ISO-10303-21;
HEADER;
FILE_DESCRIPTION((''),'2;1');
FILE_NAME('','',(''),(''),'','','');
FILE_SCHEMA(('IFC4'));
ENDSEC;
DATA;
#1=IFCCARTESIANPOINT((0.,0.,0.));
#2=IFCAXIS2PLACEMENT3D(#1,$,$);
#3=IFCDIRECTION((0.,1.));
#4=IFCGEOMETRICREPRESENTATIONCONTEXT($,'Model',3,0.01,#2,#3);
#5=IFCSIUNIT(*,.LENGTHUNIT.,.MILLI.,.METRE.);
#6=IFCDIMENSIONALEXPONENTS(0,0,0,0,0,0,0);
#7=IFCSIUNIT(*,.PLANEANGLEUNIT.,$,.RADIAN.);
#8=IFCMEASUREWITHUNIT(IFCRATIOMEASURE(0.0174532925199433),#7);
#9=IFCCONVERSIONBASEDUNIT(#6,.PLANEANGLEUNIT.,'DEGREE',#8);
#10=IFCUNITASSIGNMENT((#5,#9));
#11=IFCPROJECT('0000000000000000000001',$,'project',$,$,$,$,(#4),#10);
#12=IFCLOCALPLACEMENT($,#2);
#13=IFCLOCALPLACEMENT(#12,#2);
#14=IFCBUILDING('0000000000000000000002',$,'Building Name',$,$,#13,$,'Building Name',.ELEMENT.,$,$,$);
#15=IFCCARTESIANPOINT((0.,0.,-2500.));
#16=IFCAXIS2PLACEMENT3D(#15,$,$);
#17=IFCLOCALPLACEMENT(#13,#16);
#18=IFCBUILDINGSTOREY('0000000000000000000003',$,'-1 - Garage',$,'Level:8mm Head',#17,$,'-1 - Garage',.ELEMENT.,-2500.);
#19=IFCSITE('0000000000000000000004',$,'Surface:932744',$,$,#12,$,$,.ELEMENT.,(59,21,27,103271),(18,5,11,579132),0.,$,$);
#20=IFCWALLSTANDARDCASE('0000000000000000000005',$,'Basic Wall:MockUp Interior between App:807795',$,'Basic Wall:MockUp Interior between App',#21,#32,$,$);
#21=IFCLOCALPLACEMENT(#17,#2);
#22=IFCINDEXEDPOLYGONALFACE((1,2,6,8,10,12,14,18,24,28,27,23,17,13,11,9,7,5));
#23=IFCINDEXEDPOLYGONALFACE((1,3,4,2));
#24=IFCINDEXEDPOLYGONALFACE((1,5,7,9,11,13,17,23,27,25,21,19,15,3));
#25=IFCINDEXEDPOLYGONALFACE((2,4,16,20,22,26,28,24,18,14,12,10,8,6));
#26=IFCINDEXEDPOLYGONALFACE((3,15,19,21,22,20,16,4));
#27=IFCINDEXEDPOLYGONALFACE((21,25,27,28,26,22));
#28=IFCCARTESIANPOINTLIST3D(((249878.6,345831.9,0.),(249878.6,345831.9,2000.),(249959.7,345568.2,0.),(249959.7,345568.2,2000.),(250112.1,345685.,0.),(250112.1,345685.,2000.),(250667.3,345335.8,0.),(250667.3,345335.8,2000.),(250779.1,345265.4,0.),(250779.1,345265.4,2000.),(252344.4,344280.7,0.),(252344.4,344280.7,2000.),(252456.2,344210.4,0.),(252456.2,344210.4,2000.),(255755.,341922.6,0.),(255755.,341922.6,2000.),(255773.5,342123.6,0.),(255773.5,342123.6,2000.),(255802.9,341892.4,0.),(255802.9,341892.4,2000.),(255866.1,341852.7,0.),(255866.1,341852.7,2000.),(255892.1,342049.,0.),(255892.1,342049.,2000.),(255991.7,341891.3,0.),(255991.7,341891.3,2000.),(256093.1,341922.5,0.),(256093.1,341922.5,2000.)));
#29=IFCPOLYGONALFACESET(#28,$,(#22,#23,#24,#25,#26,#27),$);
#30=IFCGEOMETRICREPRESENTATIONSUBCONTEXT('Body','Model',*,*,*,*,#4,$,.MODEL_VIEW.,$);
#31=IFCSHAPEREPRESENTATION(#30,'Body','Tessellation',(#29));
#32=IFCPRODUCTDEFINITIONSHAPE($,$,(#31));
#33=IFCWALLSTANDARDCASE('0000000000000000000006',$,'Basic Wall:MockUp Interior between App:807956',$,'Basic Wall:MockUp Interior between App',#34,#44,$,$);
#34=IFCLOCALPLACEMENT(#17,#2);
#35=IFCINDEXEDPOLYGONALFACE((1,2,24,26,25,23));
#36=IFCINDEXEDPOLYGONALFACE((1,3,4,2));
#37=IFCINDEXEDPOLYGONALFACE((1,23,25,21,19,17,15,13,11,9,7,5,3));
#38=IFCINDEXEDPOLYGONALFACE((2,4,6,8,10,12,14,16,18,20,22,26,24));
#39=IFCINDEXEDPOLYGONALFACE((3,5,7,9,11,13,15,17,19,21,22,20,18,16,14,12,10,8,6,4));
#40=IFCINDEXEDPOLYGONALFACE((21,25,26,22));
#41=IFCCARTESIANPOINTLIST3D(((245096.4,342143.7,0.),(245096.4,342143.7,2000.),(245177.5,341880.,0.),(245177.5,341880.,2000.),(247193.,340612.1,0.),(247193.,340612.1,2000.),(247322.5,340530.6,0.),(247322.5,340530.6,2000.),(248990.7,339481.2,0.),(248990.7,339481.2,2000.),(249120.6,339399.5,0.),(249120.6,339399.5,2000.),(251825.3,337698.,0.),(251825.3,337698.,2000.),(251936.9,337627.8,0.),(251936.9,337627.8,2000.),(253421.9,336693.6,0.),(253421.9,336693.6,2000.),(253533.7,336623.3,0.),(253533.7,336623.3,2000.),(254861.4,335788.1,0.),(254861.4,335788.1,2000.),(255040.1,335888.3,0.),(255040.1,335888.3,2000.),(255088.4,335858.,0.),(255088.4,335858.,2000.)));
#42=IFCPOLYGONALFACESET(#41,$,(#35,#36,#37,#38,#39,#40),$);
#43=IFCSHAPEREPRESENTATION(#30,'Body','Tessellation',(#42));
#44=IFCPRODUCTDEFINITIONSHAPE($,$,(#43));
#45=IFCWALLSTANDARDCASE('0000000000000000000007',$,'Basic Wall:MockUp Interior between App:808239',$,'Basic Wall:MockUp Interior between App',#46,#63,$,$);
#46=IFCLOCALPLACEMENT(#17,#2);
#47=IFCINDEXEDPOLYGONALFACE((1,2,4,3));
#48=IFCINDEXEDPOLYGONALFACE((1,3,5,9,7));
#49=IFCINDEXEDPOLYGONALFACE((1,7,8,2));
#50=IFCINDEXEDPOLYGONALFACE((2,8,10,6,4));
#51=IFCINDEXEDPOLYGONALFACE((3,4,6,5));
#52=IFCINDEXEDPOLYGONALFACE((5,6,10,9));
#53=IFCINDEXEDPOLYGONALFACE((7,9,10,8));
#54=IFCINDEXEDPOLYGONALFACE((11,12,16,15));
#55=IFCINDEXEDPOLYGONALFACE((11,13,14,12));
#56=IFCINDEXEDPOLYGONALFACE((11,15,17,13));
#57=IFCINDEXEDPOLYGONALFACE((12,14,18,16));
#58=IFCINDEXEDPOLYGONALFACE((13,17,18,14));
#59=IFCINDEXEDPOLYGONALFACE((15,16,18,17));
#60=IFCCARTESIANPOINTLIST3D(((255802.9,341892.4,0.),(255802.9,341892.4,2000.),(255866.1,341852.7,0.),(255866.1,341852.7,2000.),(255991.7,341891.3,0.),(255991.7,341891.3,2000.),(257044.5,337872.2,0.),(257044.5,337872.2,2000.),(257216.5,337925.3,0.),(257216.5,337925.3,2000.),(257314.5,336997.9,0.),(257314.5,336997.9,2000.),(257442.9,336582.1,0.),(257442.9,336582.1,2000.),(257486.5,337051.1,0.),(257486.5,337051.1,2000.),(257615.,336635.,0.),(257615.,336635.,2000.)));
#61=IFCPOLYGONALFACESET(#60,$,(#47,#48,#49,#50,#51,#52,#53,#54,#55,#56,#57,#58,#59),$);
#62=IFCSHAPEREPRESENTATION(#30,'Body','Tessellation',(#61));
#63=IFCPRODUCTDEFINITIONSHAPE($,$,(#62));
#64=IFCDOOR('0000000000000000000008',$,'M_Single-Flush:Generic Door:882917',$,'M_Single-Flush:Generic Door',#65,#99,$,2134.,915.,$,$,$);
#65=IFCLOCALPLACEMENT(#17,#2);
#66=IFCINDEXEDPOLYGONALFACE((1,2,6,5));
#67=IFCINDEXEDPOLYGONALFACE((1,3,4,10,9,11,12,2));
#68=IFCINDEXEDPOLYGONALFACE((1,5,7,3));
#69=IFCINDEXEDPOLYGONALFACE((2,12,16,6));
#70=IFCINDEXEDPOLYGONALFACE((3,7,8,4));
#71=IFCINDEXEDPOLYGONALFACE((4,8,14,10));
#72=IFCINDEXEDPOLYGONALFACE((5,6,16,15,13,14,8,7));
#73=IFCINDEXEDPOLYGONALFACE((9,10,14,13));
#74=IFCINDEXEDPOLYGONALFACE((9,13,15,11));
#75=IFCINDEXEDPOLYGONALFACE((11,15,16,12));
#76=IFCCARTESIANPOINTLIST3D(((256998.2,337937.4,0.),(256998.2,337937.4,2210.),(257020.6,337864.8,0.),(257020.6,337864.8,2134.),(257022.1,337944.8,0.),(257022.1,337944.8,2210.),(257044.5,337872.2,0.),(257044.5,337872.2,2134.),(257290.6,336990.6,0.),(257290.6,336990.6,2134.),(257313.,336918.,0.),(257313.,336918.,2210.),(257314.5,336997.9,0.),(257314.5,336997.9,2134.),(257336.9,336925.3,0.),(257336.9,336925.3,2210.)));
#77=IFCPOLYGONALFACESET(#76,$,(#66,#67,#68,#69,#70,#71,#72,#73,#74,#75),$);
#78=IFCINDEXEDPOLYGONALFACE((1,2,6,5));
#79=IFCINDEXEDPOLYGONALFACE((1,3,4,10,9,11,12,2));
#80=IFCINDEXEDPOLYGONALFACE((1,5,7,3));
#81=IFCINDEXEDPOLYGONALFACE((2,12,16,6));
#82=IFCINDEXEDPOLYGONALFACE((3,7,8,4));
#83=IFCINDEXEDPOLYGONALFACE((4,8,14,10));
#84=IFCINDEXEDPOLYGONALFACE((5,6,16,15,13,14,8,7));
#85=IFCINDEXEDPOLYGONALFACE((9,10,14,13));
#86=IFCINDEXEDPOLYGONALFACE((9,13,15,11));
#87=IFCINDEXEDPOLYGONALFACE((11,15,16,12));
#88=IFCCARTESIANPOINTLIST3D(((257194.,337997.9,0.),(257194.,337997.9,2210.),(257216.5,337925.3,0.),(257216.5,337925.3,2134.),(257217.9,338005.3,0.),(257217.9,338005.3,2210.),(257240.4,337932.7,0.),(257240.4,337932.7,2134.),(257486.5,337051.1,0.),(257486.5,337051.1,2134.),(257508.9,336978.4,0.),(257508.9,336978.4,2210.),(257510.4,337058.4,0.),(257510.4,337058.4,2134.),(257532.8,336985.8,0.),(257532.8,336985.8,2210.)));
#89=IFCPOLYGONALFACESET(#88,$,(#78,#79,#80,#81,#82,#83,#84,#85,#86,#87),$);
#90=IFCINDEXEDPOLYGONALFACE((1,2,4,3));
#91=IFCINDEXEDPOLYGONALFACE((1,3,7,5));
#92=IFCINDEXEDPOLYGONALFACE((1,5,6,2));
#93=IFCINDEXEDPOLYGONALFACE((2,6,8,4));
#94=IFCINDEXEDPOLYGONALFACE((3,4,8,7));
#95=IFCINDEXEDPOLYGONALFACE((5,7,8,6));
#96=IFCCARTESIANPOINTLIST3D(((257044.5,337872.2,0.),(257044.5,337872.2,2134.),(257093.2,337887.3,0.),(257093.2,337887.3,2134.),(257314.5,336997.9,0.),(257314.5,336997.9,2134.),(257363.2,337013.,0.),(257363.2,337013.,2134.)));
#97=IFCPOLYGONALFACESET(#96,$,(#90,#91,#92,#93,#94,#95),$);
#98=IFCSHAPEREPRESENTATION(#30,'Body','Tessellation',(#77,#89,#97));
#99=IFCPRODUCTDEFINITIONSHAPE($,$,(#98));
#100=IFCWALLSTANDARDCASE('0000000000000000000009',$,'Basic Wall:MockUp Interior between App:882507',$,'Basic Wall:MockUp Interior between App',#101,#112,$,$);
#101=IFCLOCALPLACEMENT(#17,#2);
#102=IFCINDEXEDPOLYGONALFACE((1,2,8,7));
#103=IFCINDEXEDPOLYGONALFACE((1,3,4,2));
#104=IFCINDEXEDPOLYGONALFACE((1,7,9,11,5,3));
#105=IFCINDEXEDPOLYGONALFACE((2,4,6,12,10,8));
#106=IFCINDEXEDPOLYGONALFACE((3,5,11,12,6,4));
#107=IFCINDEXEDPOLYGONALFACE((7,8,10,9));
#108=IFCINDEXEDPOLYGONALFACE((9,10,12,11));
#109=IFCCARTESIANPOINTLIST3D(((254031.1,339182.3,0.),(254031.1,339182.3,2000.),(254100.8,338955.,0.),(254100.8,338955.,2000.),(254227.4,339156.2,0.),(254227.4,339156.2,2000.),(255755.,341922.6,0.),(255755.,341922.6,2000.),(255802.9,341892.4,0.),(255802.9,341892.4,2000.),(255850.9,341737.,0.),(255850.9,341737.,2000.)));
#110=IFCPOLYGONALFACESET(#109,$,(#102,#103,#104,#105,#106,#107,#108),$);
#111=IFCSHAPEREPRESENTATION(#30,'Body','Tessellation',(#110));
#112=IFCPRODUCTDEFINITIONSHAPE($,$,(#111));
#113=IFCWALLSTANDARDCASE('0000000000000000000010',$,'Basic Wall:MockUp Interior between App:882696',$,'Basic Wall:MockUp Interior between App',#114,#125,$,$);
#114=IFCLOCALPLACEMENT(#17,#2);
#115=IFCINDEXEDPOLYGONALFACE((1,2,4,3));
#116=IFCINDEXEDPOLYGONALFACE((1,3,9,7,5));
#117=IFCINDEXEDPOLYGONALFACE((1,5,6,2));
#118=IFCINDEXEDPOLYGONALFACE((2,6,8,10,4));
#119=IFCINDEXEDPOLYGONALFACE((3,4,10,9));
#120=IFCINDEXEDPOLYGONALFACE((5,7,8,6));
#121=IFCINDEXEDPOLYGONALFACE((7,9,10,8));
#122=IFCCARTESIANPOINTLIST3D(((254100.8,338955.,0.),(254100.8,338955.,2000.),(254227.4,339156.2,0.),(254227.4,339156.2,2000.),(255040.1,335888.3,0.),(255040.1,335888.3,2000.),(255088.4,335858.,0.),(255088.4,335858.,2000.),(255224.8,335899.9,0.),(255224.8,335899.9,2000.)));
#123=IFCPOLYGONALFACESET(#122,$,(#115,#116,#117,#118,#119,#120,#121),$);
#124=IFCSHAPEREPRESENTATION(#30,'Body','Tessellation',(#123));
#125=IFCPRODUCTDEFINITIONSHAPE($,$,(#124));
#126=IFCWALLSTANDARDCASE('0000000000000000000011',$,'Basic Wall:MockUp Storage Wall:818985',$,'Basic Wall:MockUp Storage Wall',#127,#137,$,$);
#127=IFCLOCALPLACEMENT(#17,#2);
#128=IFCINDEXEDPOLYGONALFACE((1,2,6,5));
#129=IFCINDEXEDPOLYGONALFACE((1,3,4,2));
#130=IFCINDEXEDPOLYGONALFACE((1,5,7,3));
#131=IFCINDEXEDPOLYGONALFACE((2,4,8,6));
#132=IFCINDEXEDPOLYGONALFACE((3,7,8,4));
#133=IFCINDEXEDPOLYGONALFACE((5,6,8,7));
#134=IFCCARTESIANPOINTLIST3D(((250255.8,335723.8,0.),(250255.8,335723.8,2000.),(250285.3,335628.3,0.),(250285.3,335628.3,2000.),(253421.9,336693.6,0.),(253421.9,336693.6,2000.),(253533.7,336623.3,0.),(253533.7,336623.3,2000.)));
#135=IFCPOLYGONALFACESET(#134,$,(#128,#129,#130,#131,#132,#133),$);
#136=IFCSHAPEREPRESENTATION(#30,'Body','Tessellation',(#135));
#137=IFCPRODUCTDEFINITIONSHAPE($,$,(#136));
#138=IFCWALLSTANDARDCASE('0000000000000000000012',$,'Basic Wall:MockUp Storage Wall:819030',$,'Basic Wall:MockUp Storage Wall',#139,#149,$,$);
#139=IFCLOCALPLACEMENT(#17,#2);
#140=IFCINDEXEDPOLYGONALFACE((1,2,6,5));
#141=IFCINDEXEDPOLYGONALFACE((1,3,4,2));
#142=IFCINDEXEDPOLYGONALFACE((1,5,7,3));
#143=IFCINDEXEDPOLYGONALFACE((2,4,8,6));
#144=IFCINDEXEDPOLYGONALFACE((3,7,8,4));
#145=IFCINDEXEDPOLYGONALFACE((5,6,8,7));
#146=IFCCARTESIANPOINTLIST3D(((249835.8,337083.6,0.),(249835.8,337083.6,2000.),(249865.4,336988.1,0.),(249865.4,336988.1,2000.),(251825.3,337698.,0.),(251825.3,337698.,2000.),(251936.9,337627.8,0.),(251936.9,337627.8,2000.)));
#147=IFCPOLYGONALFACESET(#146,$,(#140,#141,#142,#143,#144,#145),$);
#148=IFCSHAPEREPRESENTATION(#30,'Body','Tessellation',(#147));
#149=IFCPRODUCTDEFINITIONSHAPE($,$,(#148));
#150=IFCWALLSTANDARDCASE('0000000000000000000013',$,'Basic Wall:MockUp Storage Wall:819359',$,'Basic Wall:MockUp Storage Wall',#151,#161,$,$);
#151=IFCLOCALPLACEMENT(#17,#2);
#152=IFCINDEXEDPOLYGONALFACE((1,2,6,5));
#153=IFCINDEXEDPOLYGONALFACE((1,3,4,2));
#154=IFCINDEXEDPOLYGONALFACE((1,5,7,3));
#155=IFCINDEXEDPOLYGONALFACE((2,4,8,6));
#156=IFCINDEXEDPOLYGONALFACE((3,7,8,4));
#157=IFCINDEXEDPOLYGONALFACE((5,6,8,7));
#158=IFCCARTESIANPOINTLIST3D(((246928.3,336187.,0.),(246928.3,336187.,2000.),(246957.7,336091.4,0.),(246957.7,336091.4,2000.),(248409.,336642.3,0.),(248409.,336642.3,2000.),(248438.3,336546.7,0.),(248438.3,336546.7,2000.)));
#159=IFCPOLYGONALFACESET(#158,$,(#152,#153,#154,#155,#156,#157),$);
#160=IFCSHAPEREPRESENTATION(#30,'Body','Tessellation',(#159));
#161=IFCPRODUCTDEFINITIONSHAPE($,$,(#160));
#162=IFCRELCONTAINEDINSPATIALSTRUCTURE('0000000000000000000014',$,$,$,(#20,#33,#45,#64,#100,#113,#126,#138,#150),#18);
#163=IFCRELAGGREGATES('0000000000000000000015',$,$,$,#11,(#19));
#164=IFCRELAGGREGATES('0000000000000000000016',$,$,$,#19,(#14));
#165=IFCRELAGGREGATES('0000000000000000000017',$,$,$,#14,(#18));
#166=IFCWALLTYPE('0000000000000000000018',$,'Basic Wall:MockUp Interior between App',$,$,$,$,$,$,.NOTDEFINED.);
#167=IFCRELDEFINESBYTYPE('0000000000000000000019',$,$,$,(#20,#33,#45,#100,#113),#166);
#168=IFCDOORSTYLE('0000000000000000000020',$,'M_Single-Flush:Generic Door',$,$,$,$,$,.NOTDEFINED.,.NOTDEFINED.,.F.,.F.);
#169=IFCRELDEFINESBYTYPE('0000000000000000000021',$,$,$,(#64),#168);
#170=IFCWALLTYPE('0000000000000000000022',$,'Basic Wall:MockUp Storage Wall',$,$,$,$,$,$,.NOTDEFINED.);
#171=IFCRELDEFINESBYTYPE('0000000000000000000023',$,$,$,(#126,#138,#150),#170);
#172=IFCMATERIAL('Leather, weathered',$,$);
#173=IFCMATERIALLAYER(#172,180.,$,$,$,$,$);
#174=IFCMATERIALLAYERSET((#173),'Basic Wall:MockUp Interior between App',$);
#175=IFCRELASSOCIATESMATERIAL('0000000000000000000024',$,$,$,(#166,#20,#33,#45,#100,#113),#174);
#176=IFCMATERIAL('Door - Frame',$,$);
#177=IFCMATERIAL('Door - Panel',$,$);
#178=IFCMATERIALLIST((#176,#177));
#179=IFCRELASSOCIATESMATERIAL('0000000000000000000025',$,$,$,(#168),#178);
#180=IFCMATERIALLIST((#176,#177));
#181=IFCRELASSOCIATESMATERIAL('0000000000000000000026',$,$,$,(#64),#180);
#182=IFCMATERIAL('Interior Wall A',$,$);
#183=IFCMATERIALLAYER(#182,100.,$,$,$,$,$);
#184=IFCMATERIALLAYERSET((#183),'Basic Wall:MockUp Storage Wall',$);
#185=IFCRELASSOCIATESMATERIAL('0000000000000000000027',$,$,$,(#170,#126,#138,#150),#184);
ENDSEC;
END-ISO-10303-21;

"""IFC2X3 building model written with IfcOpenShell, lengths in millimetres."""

from ifc_helpers import new_model, entity, si_unit, converted_unit, direction, frame, frame_2d, origin, place, context, subcontext, project, spatial, polyline, rectangle, outline, extrude, source, transform, mapped, material, material_list, layer, layer_set, layer_usage, type_object, type_shapes, element, fill, save


model = new_model("IFC2X3")

# Units and contexts
model_context = context("Model", 3, precision=0.01, world=origin(), true_north=direction((0.0, 1.0)))
body_context = subcontext(model_context, "Body", "Model", "MODEL_VIEW")
ifc_project = project(units=[si_unit("LENGTHUNIT", "METRE", prefix="MILLI"), converted_unit("PLANEANGLEUNIT", "DEGREE", entity("IfcRatioMeasure", 0.0174532925199433), si_unit("PLANEANGLEUNIT", "RADIAN"), dimensions=[0, 0, 0, 0, 0, 0, 0])], contexts=[model_context])

# Site, building, storey
site_placement = place(None, origin())
site = spatial("IfcSite", under=ifc_project, at=site_placement, Name="Surface:932744", CompositionType="ELEMENT", RefLatitude=(59, 21, 27, 103271), RefLongitude=(18, 5, 11, 579132), RefElevation=0.0)
building_placement = place(site_placement, origin())
building = spatial("IfcBuilding", under=site, at=building_placement, Name="Building Name", LongName="Building Name", CompositionType="ELEMENT")
storey_placement = place(building_placement, frame((0.0, 0.0, -2500.0)))
storey = spatial("IfcBuildingStorey", under=building, at=storey_placement, Name="-1 - Garage", ObjectType="Level:8mm Head", LongName="-1 - Garage", CompositionType="ELEMENT", Elevation=-2500.0)

# Shared definitions
ifc_material_1 = material(Name="Leather, weathered")
ifc_layer_1 = layer(ifc_material_1, 180.0)
ifc_layer_set_1 = layer_set([ifc_layer_1], Name="Basic Wall:MockUp Interior between App")
wall_type_1 = type_object("IfcWallType", Name="Basic Wall:MockUp Interior between App", PredefinedType="NOTDEFINED", material=ifc_layer_set_1)
ifc_material_2 = material(Name="Door - Frame")
ifc_material_3 = material(Name="Door - Panel")

# Walls
ifc_layer_usage_1 = layer_usage(ifc_layer_set_1, "AXIS2", "NEGATIVE", 90.0)
wall_1_placement = place(storey_placement, frame((249830.7, 345755.7, 0.0), z_axis=(0.0, 0.0, 1.0), x_axis=(0.846444, -0.532477, 0.0)))
element("IfcWallStandardCase", 1, at=wall_1_placement, inside=storey, type_object=wall_type_1, material=ifc_layer_usage_1, Name="Basic Wall:MockUp Interior between App:807795", ObjectType="Basic Wall:MockUp Interior between App", context=body_context, shape_type="SweptSolid", body=[
    extrude(outline(polyline([(7186.9, -90.0), (7272.7, 9.6), (7341.9, 90.0), (7104.4, 90.0), (6964.3, 90.0), (3045.3, 90.0), (2913.2, 90.0), (1063.9, 90.0), (931.8, 90.0), (275.9, 90.0), (0.0, 90.0), (209.1, -90.0), (7055.7, -90.0), (7112.3, -90.0), (7186.9, -90.0)])), origin(), (0.0, 0.0, 1.0), 2000.0),
])
ifc_layer_usage_2 = layer_usage(ifc_layer_set_1, "AXIS2", "NEGATIVE", 90.0)
wall_2_placement = place(storey_placement, frame((245048.4, 342067.5, 0.0), z_axis=(0.0, 0.0, 1.0), x_axis=(0.846444, -0.532477, 0.0)))
element("IfcWallStandardCase", 2, at=wall_2_placement, inside=storey, type_object=wall_type_1, material=ifc_layer_usage_2, Name="Basic Wall:MockUp Interior between App:807956", ObjectType="Basic Wall:MockUp Interior between App", context=body_context, shape_type="SweptSolid", body=[
    extrude(outline(polyline([(11649.7, -90.0), (11804.7, 90.0), (11747.7, 90.0), (0.0, 90.0), (209.0, -90.0), (2590.2, -90.0), (2743.2, -90.0), (4714.1, -90.0), (4867.5, -90.0), (8062.9, -90.0), (8194.7, -90.0), (9949.1, -90.0), (10081.2, -90.0), (11649.7, -90.0)])), origin(), (0.0, 0.0, 1.0), 2000.0),
])

# Wall, opening, door
ifc_layer_usage_3 = layer_usage(ifc_layer_set_1, "AXIS2", "NEGATIVE", 90.0)
wall_3_placement = place(storey_placement, frame((255888.9, 341919.0, 0.0), z_axis=(0.0, 0.0, 1.0), x_axis=(0.29508, -0.955473, 0.0)))
wall_3 = element("IfcWallStandardCase", 3, at=wall_3_placement, inside=storey, type_object=wall_type_1, material=ifc_layer_usage_3, Name="Basic Wall:MockUp Interior between App:808239", ObjectType="Basic Wall:MockUp Interior between App", context=body_context, shape_type="SweptSolid", body=[
    extrude(outline(polyline([(56.8, 90.0), (56.6, -41.4), (0.0, -90.0), (5557.8, -90.0), (5558.0, 90.0), (56.8, 90.0)])), origin(), (0.0, 0.0, 1.0), 2000.0),
])
opening_1_placement = place(wall_3_placement, frame((5122.6, 90.0, 0.0)))
opening_1 = element("IfcOpeningElement", 4, at=opening_1_placement, cuts=wall_3, ObjectType="Opening", context=body_context, shape_type="SweptSolid", body=[
    extrude(rectangle(XDim=915.0, YDim=2134.0, at=frame_2d((1067.0, 457.5), x_axis=(0.0, -1.0))), frame((0.0, 0.0, 0.0), z_axis=(0.0, -1.0, 0.0), x_axis=(0.0, 0.0, 1.0)), (0.0, 0.0, 1.0), 180.0),
])
ifc_material_list_1 = material_list([ifc_material_2, ifc_material_3])
ifc_material_list_2 = material_list([ifc_material_2, ifc_material_3])
door_style_1 = type_object("IfcDoorStyle", Name="M_Single-Flush:Generic Door", ConstructionType="NOTDEFINED", OperationType="NOTDEFINED", ParameterTakesPrecedence=False, Sizeable=False, material=ifc_material_list_2)
shared_shape_1 = source(origin(), body_context, "Body", "SweptSolid", [
    extrude(outline(polyline([(-533.5, -1124.0), (533.5, -1124.0), (533.5, 1086.0), (457.5, 1086.0), (457.5, -1048.0), (-457.5, -1048.0), (-457.5, 1086.0), (-533.5, 1086.0), (-533.5, -1124.0)])), frame((457.5, 205.0, 1086.0), z_axis=(0.0, -1.0, 0.0), x_axis=(-1.0, 0.0, 0.0)), (0.0, 0.0, 1.0), 25.0),
    extrude(outline(polyline([(-1124.0, -533.5), (1086.0, -533.5), (1086.0, -457.5), (-1048.0, -457.5), (-1048.0, 457.5), (1086.0, 457.5), (1086.0, 533.5), (-1124.0, 533.5), (-1124.0, -533.5)])), frame((457.5, 0.0, 1086.0), z_axis=(0.0, -1.0, 0.0), x_axis=(0.0, 0.0, -1.0)), (0.0, 0.0, 1.0), 25.0),
    extrude(rectangle(XDim=915.0, YDim=51.0, at=frame_2d((0.0, 0.0), x_axis=(1.0, 0.0))), frame((457.5, 154.5, 0.0)), (0.0, 0.0, 1.0), 2134.0),
])
type_shapes(door_style_1, [shared_shape_1])
door_1_placement = place(opening_1_placement, frame((0.0, 0.0, 0.0), z_axis=(0.0, 0.0, 1.0), x_axis=(-1.0, 0.0, 0.0)))
door_1 = element("IfcDoor", 5, at=door_1_placement, inside=storey, type_object=door_style_1, material=ifc_material_list_1, Name="M_Single-Flush:Generic Door:882917", ObjectType="M_Single-Flush:Generic Door", OverallHeight=2134.0, OverallWidth=915.0, context=body_context, shape_type="MappedRepresentation", body=[
    mapped(shared_shape_1, transform((0.0, 0.0, 0.0), scale=1.0)),
])
fill(opening_1, door_1)

# Walls
ifc_layer_usage_4 = layer_usage(ifc_layer_set_1, "AXIS2", "NEGATIVE", 90.0)
wall_4_placement = place(storey_placement, frame((255831.1, 341874.6, 0.0), z_axis=(0.0, 0.0, 1.0), x_axis=(-0.532477, -0.846444, 0.0)))
element("IfcWallStandardCase", 6, at=wall_4_placement, inside=storey, type_object=wall_type_1, material=ifc_layer_usage_4, Name="Basic Wall:MockUp Interior between App:882507", ObjectType="Basic Wall:MockUp Interior between App", context=body_context, shape_type="SweptSolid", body=[
    extrude(outline(polyline([(3237.4, -90.0), (3392.7, 90.0), (3155.0, 90.0), (106.0, 90.0), (0.0, -33.3), (0.0, -90.0), (3237.4, -90.0)])), origin(), (0.0, 0.0, 1.0), 2000.0),
])
ifc_layer_usage_5 = layer_usage(ifc_layer_set_1, "AXIS2", "NEGATIVE", 90.0)
wall_5_placement = place(storey_placement, frame((254141.3, 339129.9, 0.0), z_axis=(0.0, 0.0, 1.0), x_axis=(0.29288, -0.956149, 0.0)))
element("IfcWallStandardCase", 7, at=wall_5_placement, inside=storey, type_object=wall_type_1, material=ifc_layer_usage_5, Name="Basic Wall:MockUp Interior between App:882696", ObjectType="Basic Wall:MockUp Interior between App", context=body_context, shape_type="SweptSolid", body=[
    extrude(outline(polyline([(3362.6, -90.0), (3405.8, -52.7), (3405.6, 90.0), (0.0, 90.0), (155.4, -90.0), (3362.6, -90.0)])), origin(), (0.0, 0.0, 1.0), 2000.0),
])

# Shared definitions
ifc_material_4 = material(Name="Interior Wall A")
ifc_layer_2 = layer(ifc_material_4, 100.0)
ifc_layer_set_2 = layer_set([ifc_layer_2], Name="Basic Wall:MockUp Storage Wall")
wall_type_2 = type_object("IfcWallType", Name="Basic Wall:MockUp Storage Wall", PredefinedType="NOTDEFINED", material=ifc_layer_set_2)

# Walls
ifc_layer_usage_6 = layer_usage(ifc_layer_set_2, "AXIS2", "NEGATIVE", 50.0)
wall_6_placement = place(storey_placement, frame((250270.4, 335676.0, 0.0), z_axis=(0.0, 0.0, 1.0), x_axis=(0.956149, 0.29288, 0.0)))
element("IfcWallStandardCase", 8, at=wall_6_placement, inside=storey, type_object=wall_type_2, material=ifc_layer_usage_6, Name="Basic Wall:MockUp Storage Wall:818985", ObjectType="Basic Wall:MockUp Storage Wall", context=body_context, shape_type="SweptSolid", body=[
    extrude(outline(polyline([(3397.6, -50.0), (3311.3, 50.0), (0.0, 50.0), (0.2, -50.0), (3397.6, -50.0)])), origin(), (0.0, 0.0, 1.0), 2000.0),
])
ifc_layer_usage_7 = layer_usage(ifc_layer_set_2, "AXIS2", "NEGATIVE", 50.0)
wall_7_placement = place(storey_placement, frame((249850.6, 337035.8, 0.0), z_axis=(0.0, 0.0, 1.0), x_axis=(0.955473, 0.29508, 0.0)))
element("IfcWallStandardCase", 9, at=wall_7_placement, inside=storey, type_object=wall_type_2, material=ifc_layer_usage_7, Name="Basic Wall:MockUp Storage Wall:819030", ObjectType="Basic Wall:MockUp Storage Wall", context=body_context, shape_type="SweptSolid", body=[
    extrude(outline(polyline([(2168.1, -50.0), (2082.2, 50.0), (0.0, 50.0), (0.0, -50.0), (2168.1, -50.0)])), origin(), (0.0, 0.0, 1.0), 2000.0),
])
ifc_layer_usage_8 = layer_usage(ifc_layer_set_2, "AXIS2", "NEGATIVE", 50.0)
wall_8_placement = place(storey_placement, frame((248423.7, 336594.5, 0.0), z_axis=(0.0, 0.0, 1.0), x_axis=(-0.955818, -0.293958, 0.0)))
element("IfcWallStandardCase", 10, at=wall_8_placement, inside=storey, type_object=wall_type_2, material=ifc_layer_usage_8, Name="Basic Wall:MockUp Storage Wall:819359", ObjectType="Basic Wall:MockUp Storage Wall", context=body_context, shape_type="SweptSolid", body=[
    extrude(outline(polyline([(1549.1, -50.0), (1549.1, 50.0), (0.1, 50.0), (0.0, -50.0), (1549.1, -50.0)])), origin(), (0.0, 0.0, 1.0), 2000.0),
])

save(model, "model.ifc")
